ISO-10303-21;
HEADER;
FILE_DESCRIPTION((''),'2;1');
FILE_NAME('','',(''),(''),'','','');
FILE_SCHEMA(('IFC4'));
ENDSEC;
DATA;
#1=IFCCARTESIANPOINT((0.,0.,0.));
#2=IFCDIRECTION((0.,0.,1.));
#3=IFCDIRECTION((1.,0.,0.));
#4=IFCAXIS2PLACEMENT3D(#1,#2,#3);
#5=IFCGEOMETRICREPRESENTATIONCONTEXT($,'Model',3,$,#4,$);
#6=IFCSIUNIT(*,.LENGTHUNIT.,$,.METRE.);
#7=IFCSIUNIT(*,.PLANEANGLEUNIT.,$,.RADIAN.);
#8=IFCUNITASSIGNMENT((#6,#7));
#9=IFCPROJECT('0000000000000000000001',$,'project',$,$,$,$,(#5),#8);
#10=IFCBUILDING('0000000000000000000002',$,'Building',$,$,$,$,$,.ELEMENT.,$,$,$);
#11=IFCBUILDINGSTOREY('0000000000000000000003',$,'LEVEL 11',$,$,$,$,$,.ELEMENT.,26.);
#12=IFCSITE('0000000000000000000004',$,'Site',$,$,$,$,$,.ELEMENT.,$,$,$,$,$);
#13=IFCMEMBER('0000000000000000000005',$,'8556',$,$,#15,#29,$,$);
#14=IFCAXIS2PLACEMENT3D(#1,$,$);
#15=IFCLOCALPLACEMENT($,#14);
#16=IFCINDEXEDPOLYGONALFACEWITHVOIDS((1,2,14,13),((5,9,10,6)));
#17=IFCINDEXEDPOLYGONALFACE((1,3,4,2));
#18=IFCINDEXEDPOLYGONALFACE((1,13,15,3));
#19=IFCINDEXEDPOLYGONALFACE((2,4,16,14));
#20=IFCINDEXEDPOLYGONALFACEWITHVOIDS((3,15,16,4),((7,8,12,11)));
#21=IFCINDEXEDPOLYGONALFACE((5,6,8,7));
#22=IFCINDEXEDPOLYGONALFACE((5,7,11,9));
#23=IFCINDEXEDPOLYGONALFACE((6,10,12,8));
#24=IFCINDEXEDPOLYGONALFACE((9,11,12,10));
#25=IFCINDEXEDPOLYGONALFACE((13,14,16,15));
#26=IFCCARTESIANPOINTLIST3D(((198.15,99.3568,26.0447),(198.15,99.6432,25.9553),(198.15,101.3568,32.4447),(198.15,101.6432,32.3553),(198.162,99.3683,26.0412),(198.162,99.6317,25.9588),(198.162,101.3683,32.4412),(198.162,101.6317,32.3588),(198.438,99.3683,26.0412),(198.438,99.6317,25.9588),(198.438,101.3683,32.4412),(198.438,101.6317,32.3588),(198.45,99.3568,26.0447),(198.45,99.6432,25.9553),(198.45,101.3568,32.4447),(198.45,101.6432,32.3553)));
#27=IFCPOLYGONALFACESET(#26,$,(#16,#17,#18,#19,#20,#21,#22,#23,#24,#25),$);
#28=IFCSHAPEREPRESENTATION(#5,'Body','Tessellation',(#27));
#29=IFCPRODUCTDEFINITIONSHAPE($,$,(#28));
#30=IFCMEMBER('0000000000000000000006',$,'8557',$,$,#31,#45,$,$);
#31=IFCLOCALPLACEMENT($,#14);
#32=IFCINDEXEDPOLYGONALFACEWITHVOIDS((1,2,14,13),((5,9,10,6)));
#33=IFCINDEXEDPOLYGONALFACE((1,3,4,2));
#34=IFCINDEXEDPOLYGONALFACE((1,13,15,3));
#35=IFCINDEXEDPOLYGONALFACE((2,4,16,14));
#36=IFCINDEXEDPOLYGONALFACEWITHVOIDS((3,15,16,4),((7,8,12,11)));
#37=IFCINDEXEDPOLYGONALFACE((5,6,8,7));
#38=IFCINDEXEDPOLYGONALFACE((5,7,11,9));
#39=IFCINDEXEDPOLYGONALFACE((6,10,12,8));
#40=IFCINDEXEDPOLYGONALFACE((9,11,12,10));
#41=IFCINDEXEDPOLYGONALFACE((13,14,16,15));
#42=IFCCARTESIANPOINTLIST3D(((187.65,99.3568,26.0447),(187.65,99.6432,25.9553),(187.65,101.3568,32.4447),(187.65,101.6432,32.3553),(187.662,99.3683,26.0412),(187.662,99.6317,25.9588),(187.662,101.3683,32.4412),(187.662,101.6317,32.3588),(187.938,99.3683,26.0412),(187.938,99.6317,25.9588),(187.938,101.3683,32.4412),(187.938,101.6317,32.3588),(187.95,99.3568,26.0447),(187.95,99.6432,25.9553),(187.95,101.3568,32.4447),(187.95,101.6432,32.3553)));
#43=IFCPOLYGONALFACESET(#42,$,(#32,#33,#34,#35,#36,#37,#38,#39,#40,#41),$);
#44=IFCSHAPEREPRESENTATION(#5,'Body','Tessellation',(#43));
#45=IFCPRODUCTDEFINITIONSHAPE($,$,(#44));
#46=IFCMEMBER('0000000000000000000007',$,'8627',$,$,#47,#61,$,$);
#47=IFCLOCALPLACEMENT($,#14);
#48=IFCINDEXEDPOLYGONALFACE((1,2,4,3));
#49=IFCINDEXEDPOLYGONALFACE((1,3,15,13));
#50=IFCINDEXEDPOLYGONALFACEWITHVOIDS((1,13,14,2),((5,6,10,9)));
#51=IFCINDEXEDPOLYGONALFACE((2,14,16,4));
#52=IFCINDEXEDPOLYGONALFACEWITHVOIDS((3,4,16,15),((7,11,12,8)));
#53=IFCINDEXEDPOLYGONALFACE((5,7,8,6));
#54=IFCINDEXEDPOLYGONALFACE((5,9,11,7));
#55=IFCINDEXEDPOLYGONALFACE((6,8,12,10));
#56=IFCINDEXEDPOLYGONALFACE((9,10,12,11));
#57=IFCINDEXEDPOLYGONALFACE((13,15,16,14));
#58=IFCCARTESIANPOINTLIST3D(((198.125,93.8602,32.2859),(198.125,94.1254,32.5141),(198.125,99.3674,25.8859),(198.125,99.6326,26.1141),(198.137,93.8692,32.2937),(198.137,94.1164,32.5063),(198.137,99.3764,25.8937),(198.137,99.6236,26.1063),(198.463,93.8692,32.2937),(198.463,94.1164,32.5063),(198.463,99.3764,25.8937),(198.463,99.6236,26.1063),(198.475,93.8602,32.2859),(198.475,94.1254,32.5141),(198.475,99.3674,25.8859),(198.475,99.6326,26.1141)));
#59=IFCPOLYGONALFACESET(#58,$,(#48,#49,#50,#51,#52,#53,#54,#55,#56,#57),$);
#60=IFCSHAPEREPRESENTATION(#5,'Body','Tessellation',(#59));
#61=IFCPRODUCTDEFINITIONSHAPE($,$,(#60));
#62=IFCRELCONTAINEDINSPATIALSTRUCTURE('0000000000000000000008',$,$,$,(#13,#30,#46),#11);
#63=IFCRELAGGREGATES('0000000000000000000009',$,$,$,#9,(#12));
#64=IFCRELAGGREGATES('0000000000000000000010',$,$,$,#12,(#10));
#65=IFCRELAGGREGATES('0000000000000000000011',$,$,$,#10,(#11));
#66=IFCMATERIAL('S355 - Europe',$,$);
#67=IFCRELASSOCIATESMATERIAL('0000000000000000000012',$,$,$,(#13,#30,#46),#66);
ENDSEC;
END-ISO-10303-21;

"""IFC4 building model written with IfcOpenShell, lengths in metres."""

from ifc_helpers import new_model, si_unit, frame, origin_with_axes, origin_2d_with_axis, place, context, project, spatial, hollow_rectangle, extrude, material, material_profile, profile_set, profile_usage, element, save


model = new_model("IFC4")

# Units and contexts
model_context = context("Model", 3, world=origin_with_axes())
ifc_project = project(units=[si_unit("LENGTHUNIT", "METRE"), si_unit("PLANEANGLEUNIT", "RADIAN")], contexts=[model_context])

# Site, building, storey
site = spatial("IfcSite", under=ifc_project, Name="Site", CompositionType="ELEMENT")
building = spatial("IfcBuilding", under=site, Name="Building", CompositionType="ELEMENT")
storey = spatial("IfcBuildingStorey", under=building, Name="LEVEL 11", CompositionType="ELEMENT", Elevation=26.0)

# Shared definitions
ifc_material = material(Name="S355 - Europe")

# Members
ifc_material_profile_1 = material_profile(ifc_material, hollow_rectangle(XDim=0.3, YDim=0.3, WallThickness=0.012, at=origin_2d_with_axis()))
ifc_profile_set_1 = profile_set([ifc_material_profile_1])
ifc_profile_usage_1 = profile_usage(ifc_profile_set_1, cardinal=10)
member_1_placement = place(None, frame((198.3, 101.5, 32.4), z_axis=(0.0, -0.298275, -0.95448), x_axis=(1.0, 0.0, 0.0)))
element("IfcMember", 1, at=member_1_placement, inside=storey, material=ifc_profile_usage_1, Name="8556", context=model_context, shape_type="SweptSolid", body=[
    extrude(hollow_rectangle(XDim=0.3, YDim=0.3, WallThickness=0.012, at=origin_2d_with_axis()), origin_with_axes(), (0.0, 0.0, 1.0), 6.7052),
])
ifc_material_profile_2 = material_profile(ifc_material, hollow_rectangle(XDim=0.3, YDim=0.3, WallThickness=0.012, at=origin_2d_with_axis()))
ifc_profile_set_2 = profile_set([ifc_material_profile_2])
ifc_profile_usage_2 = profile_usage(ifc_profile_set_2, cardinal=10)
member_2_placement = place(None, frame((187.8, 101.5, 32.4), z_axis=(0.0, -0.298275, -0.95448), x_axis=(1.0, 0.0, 0.0)))
element("IfcMember", 2, at=member_2_placement, inside=storey, material=ifc_profile_usage_2, Name="8557", context=model_context, shape_type="SweptSolid", body=[
    extrude(hollow_rectangle(XDim=0.3, YDim=0.3, WallThickness=0.012, at=origin_2d_with_axis()), origin_with_axes(), (0.0, 0.0, 1.0), 6.7052),
])
ifc_material_profile_3 = material_profile(ifc_material, hollow_rectangle(XDim=0.35, YDim=0.35, WallThickness=0.012, at=origin_2d_with_axis()))
ifc_profile_set_3 = profile_set([ifc_material_profile_3])
ifc_profile_usage_3 = profile_usage(ifc_profile_set_3, cardinal=10)
member_3_placement = place(None, frame((198.3, 99.5, 26.0), z_axis=(0.0, -0.652257, 0.757998), x_axis=(1.0, 0.0, 0.0)))
element("IfcMember", 3, at=member_3_placement, inside=storey, material=ifc_profile_usage_3, Name="8627", context=model_context, shape_type="SweptSolid", body=[
    extrude(hollow_rectangle(XDim=0.35, YDim=0.35, WallThickness=0.012, at=origin_2d_with_axis()), origin_with_axes(), (0.0, 0.0, 1.0), 8.4433),
])

save(model, "model.ifc")
